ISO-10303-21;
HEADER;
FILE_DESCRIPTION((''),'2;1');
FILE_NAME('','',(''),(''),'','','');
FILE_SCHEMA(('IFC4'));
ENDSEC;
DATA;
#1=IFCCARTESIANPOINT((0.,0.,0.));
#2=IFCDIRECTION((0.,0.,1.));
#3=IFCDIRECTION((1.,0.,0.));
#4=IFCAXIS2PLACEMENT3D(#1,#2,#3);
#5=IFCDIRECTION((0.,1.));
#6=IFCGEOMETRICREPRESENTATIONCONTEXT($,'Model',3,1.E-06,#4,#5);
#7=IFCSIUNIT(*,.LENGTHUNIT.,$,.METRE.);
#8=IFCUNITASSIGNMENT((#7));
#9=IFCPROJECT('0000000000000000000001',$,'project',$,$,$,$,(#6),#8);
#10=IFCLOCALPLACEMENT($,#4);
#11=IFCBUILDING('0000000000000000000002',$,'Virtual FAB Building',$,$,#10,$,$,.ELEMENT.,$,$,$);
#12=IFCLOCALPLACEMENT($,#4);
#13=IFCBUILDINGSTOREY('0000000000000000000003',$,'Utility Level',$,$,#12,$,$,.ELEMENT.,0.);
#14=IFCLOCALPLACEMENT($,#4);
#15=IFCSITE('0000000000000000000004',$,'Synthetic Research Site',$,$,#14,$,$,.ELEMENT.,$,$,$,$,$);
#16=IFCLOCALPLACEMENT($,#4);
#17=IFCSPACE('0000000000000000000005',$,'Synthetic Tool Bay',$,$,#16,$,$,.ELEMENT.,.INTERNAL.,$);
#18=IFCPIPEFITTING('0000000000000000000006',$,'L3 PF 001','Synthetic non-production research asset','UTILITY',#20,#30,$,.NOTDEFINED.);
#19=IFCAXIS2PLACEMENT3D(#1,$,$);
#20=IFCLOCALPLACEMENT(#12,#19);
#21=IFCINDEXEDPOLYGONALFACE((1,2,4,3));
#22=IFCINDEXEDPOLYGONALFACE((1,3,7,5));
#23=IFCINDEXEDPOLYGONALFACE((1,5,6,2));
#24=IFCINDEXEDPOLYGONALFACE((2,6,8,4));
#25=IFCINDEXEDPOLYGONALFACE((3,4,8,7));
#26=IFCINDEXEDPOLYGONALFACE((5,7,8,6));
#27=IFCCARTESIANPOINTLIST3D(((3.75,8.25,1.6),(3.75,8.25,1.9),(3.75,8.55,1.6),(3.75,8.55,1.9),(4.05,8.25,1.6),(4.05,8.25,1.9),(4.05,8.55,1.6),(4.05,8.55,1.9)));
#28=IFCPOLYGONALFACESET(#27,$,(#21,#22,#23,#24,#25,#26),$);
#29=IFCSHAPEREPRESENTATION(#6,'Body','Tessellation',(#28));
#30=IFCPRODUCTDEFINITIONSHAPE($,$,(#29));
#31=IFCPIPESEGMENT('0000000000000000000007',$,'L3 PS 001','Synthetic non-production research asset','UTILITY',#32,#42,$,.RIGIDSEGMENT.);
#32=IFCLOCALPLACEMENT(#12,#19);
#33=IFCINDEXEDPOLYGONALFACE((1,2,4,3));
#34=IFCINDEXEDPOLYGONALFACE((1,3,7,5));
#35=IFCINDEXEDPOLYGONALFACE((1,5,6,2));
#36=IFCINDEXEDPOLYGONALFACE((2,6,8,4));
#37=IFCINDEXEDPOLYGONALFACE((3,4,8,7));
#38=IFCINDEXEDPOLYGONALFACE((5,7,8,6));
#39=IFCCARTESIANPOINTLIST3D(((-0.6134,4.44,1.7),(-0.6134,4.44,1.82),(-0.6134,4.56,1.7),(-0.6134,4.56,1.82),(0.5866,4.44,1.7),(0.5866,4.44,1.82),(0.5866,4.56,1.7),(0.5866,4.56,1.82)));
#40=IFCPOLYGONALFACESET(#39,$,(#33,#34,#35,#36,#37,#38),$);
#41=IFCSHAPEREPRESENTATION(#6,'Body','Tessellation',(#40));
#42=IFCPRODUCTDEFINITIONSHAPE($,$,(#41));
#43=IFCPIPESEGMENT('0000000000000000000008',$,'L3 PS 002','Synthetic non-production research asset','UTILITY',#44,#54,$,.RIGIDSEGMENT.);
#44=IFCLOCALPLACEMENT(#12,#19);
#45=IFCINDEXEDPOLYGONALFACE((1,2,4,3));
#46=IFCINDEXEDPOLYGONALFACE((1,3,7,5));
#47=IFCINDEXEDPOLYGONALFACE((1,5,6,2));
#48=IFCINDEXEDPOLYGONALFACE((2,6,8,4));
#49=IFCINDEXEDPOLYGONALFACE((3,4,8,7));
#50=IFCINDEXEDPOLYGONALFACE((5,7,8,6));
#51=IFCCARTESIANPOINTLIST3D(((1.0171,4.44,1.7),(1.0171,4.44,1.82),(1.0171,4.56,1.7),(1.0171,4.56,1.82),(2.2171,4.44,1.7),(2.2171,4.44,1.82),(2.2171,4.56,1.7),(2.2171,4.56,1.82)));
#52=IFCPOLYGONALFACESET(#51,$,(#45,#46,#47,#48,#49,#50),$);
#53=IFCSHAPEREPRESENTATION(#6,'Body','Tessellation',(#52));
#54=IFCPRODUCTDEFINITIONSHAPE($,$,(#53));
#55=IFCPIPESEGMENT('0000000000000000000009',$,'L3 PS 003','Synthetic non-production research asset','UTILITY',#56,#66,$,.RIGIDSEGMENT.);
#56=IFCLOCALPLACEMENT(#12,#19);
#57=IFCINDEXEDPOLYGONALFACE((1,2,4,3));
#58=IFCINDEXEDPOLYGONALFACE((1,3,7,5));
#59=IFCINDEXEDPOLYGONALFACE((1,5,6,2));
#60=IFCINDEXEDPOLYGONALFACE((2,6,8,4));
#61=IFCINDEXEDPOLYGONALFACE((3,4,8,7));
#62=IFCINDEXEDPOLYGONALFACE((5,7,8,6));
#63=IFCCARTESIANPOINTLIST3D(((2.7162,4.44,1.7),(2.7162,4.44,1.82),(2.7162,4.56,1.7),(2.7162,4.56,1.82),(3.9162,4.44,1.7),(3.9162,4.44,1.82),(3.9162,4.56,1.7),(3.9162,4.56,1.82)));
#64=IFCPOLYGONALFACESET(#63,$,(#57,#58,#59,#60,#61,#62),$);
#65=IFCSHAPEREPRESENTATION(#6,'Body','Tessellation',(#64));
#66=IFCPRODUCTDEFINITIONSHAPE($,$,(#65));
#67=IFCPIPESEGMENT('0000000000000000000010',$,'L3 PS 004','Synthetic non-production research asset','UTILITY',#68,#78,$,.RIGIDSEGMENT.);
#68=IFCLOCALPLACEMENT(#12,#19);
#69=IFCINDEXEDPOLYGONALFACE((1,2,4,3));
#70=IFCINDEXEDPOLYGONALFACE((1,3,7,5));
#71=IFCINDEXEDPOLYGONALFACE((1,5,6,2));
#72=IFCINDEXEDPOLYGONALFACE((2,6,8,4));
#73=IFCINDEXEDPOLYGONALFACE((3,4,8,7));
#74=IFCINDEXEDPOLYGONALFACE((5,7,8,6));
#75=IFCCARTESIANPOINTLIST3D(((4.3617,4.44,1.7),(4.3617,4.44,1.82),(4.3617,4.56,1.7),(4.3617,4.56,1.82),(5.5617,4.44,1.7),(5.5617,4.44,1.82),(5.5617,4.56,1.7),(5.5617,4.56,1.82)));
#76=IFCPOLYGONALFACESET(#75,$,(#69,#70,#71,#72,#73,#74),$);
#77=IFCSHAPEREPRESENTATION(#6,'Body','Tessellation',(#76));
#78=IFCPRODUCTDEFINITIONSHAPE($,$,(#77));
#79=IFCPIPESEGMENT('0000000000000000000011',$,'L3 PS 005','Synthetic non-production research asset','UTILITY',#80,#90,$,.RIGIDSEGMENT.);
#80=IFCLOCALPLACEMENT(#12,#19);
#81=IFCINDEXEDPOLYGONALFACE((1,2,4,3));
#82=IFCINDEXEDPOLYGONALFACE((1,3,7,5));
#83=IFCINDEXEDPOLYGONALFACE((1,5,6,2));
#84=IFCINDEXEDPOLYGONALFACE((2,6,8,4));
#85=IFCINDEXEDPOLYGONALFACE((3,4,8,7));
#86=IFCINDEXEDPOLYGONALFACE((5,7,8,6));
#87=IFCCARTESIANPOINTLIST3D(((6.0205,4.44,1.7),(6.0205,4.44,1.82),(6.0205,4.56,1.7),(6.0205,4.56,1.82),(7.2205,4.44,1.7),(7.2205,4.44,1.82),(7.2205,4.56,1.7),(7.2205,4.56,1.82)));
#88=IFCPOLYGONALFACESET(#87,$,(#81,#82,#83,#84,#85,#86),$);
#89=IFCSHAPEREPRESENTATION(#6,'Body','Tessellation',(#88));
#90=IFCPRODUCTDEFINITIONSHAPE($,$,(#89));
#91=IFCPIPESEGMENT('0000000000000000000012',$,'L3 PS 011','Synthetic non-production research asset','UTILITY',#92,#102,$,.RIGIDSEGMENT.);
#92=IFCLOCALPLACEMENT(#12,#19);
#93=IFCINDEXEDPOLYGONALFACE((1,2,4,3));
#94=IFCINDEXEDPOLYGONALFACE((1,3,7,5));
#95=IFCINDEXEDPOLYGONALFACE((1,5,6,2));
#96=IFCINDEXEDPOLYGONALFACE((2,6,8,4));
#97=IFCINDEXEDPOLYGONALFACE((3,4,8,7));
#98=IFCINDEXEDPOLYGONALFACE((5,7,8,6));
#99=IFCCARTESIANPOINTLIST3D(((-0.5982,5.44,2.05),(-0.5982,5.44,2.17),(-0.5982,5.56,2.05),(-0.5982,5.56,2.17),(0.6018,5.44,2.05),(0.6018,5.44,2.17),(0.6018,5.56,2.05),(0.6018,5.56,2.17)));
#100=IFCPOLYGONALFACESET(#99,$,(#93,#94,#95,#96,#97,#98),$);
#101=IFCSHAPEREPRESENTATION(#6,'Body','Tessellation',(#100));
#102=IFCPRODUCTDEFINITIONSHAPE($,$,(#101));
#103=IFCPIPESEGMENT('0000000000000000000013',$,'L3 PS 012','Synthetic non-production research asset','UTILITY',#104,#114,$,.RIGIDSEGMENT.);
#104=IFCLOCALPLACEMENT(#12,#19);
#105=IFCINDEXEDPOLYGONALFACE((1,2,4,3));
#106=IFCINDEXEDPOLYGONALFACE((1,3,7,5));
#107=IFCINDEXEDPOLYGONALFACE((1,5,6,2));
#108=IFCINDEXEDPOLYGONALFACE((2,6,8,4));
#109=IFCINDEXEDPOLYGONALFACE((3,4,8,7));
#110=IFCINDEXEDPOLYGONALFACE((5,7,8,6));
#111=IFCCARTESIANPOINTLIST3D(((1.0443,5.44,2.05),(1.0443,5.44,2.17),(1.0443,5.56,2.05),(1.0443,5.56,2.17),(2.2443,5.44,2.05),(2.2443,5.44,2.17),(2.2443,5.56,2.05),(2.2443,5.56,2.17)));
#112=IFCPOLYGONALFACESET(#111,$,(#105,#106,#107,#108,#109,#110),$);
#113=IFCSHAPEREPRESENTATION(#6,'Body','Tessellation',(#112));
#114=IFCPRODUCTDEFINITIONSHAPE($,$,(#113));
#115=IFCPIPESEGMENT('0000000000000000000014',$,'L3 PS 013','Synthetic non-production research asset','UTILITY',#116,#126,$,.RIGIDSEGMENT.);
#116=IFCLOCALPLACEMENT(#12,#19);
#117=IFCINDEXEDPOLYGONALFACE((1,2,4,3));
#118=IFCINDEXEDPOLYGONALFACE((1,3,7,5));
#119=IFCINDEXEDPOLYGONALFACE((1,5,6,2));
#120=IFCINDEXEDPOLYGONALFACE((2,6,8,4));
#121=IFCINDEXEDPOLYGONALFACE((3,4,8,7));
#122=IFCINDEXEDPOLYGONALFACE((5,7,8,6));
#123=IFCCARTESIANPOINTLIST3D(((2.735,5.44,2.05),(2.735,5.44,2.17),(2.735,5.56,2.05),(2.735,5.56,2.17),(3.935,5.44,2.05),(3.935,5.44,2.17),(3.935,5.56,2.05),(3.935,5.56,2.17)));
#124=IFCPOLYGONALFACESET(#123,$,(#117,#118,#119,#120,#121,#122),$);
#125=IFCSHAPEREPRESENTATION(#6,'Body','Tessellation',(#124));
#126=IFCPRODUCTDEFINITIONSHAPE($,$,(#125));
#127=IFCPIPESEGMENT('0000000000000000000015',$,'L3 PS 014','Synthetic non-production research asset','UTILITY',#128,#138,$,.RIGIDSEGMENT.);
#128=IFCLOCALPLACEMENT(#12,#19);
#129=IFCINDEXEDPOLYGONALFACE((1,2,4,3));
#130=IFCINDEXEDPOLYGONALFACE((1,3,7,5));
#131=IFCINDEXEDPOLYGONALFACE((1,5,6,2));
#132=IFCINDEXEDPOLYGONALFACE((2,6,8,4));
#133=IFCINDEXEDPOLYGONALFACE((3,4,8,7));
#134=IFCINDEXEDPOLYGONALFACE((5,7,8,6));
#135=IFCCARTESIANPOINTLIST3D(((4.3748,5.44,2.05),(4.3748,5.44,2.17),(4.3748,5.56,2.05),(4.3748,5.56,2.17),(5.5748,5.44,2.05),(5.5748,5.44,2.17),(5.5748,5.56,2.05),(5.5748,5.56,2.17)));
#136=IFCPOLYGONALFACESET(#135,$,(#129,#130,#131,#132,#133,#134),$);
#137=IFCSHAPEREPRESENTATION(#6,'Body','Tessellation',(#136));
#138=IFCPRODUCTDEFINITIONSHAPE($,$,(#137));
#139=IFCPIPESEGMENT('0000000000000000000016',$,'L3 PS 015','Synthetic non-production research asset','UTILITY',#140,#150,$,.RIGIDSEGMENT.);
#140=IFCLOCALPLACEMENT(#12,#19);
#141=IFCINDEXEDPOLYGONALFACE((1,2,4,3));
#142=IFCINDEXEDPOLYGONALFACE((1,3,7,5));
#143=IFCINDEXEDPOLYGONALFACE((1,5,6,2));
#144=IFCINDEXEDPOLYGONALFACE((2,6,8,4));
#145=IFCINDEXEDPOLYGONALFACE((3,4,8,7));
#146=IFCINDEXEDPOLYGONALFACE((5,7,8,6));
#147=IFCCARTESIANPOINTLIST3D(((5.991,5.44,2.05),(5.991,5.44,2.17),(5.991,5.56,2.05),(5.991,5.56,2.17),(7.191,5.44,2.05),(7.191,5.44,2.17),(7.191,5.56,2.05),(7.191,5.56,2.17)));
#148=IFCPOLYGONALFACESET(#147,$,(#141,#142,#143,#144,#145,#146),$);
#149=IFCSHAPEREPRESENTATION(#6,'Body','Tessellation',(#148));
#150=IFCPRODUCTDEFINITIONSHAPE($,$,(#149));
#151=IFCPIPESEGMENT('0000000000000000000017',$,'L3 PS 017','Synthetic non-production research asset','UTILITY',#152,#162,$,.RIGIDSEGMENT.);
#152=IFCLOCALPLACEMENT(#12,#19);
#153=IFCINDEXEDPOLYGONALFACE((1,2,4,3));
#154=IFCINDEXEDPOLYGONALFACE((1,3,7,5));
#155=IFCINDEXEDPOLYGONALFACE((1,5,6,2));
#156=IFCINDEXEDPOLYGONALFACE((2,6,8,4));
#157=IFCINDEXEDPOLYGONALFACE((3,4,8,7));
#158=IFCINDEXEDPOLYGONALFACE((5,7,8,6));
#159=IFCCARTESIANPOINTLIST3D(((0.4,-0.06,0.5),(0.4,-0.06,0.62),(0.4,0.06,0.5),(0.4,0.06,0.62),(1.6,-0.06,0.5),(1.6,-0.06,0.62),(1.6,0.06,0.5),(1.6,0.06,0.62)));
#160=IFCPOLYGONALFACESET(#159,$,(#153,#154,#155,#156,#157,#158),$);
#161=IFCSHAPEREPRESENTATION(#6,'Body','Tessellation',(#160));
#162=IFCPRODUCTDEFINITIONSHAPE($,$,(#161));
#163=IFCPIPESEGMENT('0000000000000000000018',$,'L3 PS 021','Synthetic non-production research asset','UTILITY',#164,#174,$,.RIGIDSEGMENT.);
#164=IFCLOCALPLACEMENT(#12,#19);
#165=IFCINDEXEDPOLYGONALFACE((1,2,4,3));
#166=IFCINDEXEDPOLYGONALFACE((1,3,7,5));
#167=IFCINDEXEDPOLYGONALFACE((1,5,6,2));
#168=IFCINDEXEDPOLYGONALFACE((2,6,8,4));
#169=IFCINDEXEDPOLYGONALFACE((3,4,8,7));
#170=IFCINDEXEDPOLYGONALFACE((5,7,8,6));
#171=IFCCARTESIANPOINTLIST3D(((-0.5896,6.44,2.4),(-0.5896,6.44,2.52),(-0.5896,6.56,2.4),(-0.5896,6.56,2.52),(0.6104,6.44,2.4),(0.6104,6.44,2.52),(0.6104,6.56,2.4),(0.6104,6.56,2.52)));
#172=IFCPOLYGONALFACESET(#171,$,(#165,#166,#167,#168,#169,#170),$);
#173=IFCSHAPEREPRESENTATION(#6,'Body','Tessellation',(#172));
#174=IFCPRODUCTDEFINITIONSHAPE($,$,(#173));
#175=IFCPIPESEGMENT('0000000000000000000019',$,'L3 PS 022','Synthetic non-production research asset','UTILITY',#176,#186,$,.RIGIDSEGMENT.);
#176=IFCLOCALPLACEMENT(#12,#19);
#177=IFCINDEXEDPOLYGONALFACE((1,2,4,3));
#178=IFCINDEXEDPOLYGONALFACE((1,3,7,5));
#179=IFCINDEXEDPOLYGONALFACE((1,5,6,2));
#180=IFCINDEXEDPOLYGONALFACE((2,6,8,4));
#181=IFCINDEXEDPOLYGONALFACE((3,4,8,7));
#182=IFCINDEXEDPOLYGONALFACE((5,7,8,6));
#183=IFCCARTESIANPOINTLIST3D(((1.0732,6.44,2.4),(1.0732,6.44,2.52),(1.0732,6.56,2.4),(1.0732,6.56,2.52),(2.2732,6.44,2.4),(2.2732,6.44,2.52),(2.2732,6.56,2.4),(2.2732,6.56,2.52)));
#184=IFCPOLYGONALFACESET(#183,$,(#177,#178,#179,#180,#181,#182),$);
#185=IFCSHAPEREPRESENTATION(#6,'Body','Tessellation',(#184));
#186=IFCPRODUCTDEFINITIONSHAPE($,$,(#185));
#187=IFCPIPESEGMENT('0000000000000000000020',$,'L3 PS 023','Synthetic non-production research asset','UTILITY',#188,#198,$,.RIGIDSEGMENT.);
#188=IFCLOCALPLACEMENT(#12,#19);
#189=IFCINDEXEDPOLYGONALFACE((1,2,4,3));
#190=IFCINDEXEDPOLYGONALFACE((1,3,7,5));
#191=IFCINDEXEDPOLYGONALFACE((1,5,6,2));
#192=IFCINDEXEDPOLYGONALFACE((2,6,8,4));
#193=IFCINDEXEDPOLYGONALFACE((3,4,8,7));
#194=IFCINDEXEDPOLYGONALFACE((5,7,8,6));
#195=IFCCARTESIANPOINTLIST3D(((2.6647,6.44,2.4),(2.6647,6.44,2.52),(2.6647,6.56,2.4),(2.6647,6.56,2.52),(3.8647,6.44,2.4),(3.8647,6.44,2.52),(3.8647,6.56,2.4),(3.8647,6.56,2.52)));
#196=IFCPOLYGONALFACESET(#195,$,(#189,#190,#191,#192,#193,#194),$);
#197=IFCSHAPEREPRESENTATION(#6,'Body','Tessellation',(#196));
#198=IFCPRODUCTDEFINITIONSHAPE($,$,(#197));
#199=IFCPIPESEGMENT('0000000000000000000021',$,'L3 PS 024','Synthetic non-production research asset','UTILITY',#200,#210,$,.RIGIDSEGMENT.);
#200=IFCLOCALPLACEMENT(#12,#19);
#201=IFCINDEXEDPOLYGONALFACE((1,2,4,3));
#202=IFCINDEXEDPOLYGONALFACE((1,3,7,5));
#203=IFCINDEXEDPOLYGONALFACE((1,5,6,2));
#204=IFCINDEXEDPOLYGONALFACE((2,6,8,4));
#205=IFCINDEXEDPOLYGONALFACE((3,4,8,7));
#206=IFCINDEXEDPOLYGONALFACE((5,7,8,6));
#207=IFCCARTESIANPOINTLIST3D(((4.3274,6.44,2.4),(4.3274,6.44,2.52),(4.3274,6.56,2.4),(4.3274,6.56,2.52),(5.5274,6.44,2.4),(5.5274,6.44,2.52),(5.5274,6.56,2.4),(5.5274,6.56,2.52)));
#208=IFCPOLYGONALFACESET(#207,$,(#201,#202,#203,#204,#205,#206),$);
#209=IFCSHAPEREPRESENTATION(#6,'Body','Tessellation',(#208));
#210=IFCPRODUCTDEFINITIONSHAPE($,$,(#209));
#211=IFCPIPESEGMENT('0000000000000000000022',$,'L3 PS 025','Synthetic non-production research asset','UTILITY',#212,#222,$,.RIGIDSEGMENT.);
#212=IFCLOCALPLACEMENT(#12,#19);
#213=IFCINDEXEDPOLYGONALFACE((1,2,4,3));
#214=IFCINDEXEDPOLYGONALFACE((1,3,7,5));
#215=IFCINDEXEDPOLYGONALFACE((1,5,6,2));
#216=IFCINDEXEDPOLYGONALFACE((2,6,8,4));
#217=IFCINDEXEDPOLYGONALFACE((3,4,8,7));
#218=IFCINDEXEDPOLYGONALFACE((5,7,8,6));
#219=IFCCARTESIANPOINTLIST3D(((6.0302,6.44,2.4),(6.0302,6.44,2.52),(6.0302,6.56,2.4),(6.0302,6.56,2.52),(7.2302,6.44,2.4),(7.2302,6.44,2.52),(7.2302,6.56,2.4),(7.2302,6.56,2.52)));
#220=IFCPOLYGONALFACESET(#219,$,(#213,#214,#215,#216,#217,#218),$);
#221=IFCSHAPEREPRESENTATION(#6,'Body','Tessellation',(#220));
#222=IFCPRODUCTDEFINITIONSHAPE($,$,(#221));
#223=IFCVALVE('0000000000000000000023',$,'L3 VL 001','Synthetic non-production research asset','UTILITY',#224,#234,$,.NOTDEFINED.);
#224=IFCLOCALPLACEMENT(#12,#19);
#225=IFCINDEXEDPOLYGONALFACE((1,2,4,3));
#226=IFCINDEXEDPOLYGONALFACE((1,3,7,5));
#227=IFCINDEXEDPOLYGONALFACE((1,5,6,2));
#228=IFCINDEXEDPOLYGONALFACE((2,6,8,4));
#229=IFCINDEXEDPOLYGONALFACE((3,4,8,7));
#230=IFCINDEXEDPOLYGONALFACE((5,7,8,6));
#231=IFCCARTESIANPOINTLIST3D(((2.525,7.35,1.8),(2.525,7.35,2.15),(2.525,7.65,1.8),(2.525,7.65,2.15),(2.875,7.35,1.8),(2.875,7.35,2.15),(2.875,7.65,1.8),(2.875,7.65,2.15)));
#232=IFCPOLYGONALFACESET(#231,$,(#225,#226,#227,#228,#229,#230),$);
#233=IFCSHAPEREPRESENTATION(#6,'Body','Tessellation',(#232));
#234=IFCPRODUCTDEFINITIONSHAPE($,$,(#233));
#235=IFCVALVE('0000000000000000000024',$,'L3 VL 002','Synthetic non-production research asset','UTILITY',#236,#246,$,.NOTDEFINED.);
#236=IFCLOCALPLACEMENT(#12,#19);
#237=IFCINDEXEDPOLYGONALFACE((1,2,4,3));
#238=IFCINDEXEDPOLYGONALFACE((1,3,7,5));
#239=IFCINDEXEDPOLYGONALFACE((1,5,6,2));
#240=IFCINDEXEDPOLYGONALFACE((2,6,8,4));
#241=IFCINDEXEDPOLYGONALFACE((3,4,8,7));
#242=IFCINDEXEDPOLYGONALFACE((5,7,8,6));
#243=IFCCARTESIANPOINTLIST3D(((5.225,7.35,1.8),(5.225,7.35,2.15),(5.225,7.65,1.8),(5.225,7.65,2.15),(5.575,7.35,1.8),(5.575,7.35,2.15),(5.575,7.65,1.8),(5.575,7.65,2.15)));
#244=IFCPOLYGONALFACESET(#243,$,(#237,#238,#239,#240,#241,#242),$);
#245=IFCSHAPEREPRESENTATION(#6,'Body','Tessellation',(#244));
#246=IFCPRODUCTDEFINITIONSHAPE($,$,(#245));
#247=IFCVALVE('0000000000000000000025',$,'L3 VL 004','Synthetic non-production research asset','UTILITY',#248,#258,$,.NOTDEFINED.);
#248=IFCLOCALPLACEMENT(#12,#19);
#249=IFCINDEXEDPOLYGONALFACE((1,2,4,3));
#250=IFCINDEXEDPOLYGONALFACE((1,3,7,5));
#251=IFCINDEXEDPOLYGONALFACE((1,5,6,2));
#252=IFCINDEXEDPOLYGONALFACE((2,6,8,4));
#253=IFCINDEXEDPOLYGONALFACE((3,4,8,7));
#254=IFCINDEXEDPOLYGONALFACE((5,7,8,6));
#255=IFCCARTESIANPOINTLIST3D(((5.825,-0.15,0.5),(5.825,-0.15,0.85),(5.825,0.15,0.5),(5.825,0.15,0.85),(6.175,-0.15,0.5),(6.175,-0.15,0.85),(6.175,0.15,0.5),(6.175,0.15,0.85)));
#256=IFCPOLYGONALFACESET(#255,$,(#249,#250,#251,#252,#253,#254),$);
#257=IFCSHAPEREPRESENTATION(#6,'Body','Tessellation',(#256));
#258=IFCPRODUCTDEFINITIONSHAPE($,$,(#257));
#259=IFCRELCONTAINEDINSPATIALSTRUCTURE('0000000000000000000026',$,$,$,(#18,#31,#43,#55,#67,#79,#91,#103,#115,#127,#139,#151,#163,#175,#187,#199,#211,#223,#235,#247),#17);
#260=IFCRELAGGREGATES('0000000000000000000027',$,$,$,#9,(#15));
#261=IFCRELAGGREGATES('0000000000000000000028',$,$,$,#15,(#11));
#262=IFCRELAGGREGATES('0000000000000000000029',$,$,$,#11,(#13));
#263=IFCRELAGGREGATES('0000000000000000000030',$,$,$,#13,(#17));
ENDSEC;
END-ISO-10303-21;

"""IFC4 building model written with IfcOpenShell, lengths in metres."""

from ifc_helpers import new_model, si_unit, direction, frame, origin_with_axes, origin_2d_with_axis, place, context, project, spatial, rectangle, extrude, element, save


model = new_model("IFC4")

# Units and contexts
model_context = context("Model", 3, precision=1e-06, world=origin_with_axes(), true_north=direction((0.0, 1.0)))
ifc_project = project(units=[si_unit("LENGTHUNIT", "METRE")], contexts=[model_context])

# Site, building, storey, space
site_placement = place(None, origin_with_axes())
site = spatial("IfcSite", under=ifc_project, at=site_placement, Name="Synthetic Research Site", CompositionType="ELEMENT")
building_placement = place(None, origin_with_axes())
building = spatial("IfcBuilding", under=site, at=building_placement, Name="Virtual FAB Building", CompositionType="ELEMENT")
storey_placement = place(None, origin_with_axes())
storey = spatial("IfcBuildingStorey", under=building, at=storey_placement, Name="Utility Level", CompositionType="ELEMENT", Elevation=0.0)
space_placement = place(None, origin_with_axes())
space = spatial("IfcSpace", under=storey, at=space_placement, Name="Synthetic Tool Bay", CompositionType="ELEMENT", PredefinedType="INTERNAL")

# Pipe fitting
pipe_fitting_placement = place(None, frame((3.9, 8.4, 1.6), z_axis=(0.0, 0.0, 1.0), x_axis=(1.0, 0.0, 0.0)))
element("IfcPipeFitting", 1, at=pipe_fitting_placement, inside=space, Name="L3 PF 001", Description="Synthetic non-production research asset", ObjectType="UTILITY", PredefinedType="NOTDEFINED", context=model_context, shape_type="SweptSolid", body=[
    extrude(rectangle(XDim=0.3, YDim=0.3, at=origin_2d_with_axis()), origin_with_axes(), (0.0, 0.0, 1.0), 0.3),
])

# Pipe segments
for number, where, z_axis, x_axis, name in (
    (2, (-0.0134, 4.5, 1.7), (0.0, 0.0, 1.0), (1.0, 0.0, 0.0), "L3 PS 001"),
    (3, (1.6171, 4.5, 1.7), (0.0, 0.0, 1.0), (1.0, 0.0, 0.0), "L3 PS 002"),
    (4, (3.3162, 4.5, 1.7), (0.0, 0.0, 1.0), (1.0, 0.0, 0.0), "L3 PS 003"),
    (5, (4.9617, 4.5, 1.7), (0.0, 0.0, 1.0), (1.0, 0.0, 0.0), "L3 PS 004"),
    (6, (6.6205, 4.5, 1.7), (0.0, 0.0, 1.0), (1.0, 0.0, 0.0), "L3 PS 005"),
    (7, (0.0018, 5.5, 2.05), (0.0, 0.0, 1.0), (1.0, 0.0, 0.0), "L3 PS 011"),
    (8, (1.6443, 5.5, 2.05), (0.0, 0.0, 1.0), (1.0, 0.0, 0.0), "L3 PS 012"),
    (9, (3.335, 5.5, 2.05), (0.0, 0.0, 1.0), (1.0, 0.0, 0.0), "L3 PS 013"),
    (10, (4.9748, 5.5, 2.05), (0.0, 0.0, 1.0), (1.0, 0.0, 0.0), "L3 PS 014"),
    (11, (6.591, 5.5, 2.05), (0.0, 0.0, 1.0), (1.0, 0.0, 0.0), "L3 PS 015"),
    (12, (1.0, 0.0, 0.5), (0.0, 0.0, 1.0), (1.0, 0.0, 0.0), "L3 PS 017"),
    (13, (0.0104, 6.5, 2.4), (0.0, 0.0, 1.0), (1.0, 0.0, 0.0), "L3 PS 021"),
    (14, (1.6732, 6.5, 2.4), (0.0, 0.0, 1.0), (1.0, 0.0, 0.0), "L3 PS 022"),
    (15, (3.2647, 6.5, 2.4), (0.0, 0.0, 1.0), (1.0, 0.0, 0.0), "L3 PS 023"),
    (16, (4.9274, 6.5, 2.4), (0.0, 0.0, 1.0), (1.0, 0.0, 0.0), "L3 PS 024"),
    (17, (6.6302, 6.5, 2.4), (0.0, 0.0, 1.0), (1.0, 0.0, 0.0), "L3 PS 025"),
):
    element("IfcPipeSegment", number, at=place(None, frame(where, z_axis=z_axis, x_axis=x_axis)), inside=space, Name=name, Description="Synthetic non-production research asset", ObjectType="UTILITY", PredefinedType="RIGIDSEGMENT", context=model_context, shape_type="SweptSolid", body=[
        extrude(rectangle(XDim=1.2, YDim=0.12, at=origin_2d_with_axis()), origin_with_axes(), (0.0, 0.0, 1.0), 0.12),
    ])

# Valves
for number, where, z_axis, x_axis, name in (
    (18, (2.7, 7.5, 1.8), (0.0, 0.0, 1.0), (1.0, 0.0, 0.0), "L3 VL 001"),
    (19, (5.4, 7.5, 1.8), (0.0, 0.0, 1.0), (1.0, 0.0, 0.0), "L3 VL 002"),
    (20, (6.0, 0.0, 0.5), (0.0, 0.0, 1.0), (1.0, 0.0, 0.0), "L3 VL 004"),
):
    element("IfcValve", number, at=place(None, frame(where, z_axis=z_axis, x_axis=x_axis)), inside=space, Name=name, Description="Synthetic non-production research asset", ObjectType="UTILITY", PredefinedType="NOTDEFINED", context=model_context, shape_type="SweptSolid", body=[
        extrude(rectangle(XDim=0.35, YDim=0.3, at=origin_2d_with_axis()), origin_with_axes(), (0.0, 0.0, 1.0), 0.35),
    ])

save(model, "model.ifc")
